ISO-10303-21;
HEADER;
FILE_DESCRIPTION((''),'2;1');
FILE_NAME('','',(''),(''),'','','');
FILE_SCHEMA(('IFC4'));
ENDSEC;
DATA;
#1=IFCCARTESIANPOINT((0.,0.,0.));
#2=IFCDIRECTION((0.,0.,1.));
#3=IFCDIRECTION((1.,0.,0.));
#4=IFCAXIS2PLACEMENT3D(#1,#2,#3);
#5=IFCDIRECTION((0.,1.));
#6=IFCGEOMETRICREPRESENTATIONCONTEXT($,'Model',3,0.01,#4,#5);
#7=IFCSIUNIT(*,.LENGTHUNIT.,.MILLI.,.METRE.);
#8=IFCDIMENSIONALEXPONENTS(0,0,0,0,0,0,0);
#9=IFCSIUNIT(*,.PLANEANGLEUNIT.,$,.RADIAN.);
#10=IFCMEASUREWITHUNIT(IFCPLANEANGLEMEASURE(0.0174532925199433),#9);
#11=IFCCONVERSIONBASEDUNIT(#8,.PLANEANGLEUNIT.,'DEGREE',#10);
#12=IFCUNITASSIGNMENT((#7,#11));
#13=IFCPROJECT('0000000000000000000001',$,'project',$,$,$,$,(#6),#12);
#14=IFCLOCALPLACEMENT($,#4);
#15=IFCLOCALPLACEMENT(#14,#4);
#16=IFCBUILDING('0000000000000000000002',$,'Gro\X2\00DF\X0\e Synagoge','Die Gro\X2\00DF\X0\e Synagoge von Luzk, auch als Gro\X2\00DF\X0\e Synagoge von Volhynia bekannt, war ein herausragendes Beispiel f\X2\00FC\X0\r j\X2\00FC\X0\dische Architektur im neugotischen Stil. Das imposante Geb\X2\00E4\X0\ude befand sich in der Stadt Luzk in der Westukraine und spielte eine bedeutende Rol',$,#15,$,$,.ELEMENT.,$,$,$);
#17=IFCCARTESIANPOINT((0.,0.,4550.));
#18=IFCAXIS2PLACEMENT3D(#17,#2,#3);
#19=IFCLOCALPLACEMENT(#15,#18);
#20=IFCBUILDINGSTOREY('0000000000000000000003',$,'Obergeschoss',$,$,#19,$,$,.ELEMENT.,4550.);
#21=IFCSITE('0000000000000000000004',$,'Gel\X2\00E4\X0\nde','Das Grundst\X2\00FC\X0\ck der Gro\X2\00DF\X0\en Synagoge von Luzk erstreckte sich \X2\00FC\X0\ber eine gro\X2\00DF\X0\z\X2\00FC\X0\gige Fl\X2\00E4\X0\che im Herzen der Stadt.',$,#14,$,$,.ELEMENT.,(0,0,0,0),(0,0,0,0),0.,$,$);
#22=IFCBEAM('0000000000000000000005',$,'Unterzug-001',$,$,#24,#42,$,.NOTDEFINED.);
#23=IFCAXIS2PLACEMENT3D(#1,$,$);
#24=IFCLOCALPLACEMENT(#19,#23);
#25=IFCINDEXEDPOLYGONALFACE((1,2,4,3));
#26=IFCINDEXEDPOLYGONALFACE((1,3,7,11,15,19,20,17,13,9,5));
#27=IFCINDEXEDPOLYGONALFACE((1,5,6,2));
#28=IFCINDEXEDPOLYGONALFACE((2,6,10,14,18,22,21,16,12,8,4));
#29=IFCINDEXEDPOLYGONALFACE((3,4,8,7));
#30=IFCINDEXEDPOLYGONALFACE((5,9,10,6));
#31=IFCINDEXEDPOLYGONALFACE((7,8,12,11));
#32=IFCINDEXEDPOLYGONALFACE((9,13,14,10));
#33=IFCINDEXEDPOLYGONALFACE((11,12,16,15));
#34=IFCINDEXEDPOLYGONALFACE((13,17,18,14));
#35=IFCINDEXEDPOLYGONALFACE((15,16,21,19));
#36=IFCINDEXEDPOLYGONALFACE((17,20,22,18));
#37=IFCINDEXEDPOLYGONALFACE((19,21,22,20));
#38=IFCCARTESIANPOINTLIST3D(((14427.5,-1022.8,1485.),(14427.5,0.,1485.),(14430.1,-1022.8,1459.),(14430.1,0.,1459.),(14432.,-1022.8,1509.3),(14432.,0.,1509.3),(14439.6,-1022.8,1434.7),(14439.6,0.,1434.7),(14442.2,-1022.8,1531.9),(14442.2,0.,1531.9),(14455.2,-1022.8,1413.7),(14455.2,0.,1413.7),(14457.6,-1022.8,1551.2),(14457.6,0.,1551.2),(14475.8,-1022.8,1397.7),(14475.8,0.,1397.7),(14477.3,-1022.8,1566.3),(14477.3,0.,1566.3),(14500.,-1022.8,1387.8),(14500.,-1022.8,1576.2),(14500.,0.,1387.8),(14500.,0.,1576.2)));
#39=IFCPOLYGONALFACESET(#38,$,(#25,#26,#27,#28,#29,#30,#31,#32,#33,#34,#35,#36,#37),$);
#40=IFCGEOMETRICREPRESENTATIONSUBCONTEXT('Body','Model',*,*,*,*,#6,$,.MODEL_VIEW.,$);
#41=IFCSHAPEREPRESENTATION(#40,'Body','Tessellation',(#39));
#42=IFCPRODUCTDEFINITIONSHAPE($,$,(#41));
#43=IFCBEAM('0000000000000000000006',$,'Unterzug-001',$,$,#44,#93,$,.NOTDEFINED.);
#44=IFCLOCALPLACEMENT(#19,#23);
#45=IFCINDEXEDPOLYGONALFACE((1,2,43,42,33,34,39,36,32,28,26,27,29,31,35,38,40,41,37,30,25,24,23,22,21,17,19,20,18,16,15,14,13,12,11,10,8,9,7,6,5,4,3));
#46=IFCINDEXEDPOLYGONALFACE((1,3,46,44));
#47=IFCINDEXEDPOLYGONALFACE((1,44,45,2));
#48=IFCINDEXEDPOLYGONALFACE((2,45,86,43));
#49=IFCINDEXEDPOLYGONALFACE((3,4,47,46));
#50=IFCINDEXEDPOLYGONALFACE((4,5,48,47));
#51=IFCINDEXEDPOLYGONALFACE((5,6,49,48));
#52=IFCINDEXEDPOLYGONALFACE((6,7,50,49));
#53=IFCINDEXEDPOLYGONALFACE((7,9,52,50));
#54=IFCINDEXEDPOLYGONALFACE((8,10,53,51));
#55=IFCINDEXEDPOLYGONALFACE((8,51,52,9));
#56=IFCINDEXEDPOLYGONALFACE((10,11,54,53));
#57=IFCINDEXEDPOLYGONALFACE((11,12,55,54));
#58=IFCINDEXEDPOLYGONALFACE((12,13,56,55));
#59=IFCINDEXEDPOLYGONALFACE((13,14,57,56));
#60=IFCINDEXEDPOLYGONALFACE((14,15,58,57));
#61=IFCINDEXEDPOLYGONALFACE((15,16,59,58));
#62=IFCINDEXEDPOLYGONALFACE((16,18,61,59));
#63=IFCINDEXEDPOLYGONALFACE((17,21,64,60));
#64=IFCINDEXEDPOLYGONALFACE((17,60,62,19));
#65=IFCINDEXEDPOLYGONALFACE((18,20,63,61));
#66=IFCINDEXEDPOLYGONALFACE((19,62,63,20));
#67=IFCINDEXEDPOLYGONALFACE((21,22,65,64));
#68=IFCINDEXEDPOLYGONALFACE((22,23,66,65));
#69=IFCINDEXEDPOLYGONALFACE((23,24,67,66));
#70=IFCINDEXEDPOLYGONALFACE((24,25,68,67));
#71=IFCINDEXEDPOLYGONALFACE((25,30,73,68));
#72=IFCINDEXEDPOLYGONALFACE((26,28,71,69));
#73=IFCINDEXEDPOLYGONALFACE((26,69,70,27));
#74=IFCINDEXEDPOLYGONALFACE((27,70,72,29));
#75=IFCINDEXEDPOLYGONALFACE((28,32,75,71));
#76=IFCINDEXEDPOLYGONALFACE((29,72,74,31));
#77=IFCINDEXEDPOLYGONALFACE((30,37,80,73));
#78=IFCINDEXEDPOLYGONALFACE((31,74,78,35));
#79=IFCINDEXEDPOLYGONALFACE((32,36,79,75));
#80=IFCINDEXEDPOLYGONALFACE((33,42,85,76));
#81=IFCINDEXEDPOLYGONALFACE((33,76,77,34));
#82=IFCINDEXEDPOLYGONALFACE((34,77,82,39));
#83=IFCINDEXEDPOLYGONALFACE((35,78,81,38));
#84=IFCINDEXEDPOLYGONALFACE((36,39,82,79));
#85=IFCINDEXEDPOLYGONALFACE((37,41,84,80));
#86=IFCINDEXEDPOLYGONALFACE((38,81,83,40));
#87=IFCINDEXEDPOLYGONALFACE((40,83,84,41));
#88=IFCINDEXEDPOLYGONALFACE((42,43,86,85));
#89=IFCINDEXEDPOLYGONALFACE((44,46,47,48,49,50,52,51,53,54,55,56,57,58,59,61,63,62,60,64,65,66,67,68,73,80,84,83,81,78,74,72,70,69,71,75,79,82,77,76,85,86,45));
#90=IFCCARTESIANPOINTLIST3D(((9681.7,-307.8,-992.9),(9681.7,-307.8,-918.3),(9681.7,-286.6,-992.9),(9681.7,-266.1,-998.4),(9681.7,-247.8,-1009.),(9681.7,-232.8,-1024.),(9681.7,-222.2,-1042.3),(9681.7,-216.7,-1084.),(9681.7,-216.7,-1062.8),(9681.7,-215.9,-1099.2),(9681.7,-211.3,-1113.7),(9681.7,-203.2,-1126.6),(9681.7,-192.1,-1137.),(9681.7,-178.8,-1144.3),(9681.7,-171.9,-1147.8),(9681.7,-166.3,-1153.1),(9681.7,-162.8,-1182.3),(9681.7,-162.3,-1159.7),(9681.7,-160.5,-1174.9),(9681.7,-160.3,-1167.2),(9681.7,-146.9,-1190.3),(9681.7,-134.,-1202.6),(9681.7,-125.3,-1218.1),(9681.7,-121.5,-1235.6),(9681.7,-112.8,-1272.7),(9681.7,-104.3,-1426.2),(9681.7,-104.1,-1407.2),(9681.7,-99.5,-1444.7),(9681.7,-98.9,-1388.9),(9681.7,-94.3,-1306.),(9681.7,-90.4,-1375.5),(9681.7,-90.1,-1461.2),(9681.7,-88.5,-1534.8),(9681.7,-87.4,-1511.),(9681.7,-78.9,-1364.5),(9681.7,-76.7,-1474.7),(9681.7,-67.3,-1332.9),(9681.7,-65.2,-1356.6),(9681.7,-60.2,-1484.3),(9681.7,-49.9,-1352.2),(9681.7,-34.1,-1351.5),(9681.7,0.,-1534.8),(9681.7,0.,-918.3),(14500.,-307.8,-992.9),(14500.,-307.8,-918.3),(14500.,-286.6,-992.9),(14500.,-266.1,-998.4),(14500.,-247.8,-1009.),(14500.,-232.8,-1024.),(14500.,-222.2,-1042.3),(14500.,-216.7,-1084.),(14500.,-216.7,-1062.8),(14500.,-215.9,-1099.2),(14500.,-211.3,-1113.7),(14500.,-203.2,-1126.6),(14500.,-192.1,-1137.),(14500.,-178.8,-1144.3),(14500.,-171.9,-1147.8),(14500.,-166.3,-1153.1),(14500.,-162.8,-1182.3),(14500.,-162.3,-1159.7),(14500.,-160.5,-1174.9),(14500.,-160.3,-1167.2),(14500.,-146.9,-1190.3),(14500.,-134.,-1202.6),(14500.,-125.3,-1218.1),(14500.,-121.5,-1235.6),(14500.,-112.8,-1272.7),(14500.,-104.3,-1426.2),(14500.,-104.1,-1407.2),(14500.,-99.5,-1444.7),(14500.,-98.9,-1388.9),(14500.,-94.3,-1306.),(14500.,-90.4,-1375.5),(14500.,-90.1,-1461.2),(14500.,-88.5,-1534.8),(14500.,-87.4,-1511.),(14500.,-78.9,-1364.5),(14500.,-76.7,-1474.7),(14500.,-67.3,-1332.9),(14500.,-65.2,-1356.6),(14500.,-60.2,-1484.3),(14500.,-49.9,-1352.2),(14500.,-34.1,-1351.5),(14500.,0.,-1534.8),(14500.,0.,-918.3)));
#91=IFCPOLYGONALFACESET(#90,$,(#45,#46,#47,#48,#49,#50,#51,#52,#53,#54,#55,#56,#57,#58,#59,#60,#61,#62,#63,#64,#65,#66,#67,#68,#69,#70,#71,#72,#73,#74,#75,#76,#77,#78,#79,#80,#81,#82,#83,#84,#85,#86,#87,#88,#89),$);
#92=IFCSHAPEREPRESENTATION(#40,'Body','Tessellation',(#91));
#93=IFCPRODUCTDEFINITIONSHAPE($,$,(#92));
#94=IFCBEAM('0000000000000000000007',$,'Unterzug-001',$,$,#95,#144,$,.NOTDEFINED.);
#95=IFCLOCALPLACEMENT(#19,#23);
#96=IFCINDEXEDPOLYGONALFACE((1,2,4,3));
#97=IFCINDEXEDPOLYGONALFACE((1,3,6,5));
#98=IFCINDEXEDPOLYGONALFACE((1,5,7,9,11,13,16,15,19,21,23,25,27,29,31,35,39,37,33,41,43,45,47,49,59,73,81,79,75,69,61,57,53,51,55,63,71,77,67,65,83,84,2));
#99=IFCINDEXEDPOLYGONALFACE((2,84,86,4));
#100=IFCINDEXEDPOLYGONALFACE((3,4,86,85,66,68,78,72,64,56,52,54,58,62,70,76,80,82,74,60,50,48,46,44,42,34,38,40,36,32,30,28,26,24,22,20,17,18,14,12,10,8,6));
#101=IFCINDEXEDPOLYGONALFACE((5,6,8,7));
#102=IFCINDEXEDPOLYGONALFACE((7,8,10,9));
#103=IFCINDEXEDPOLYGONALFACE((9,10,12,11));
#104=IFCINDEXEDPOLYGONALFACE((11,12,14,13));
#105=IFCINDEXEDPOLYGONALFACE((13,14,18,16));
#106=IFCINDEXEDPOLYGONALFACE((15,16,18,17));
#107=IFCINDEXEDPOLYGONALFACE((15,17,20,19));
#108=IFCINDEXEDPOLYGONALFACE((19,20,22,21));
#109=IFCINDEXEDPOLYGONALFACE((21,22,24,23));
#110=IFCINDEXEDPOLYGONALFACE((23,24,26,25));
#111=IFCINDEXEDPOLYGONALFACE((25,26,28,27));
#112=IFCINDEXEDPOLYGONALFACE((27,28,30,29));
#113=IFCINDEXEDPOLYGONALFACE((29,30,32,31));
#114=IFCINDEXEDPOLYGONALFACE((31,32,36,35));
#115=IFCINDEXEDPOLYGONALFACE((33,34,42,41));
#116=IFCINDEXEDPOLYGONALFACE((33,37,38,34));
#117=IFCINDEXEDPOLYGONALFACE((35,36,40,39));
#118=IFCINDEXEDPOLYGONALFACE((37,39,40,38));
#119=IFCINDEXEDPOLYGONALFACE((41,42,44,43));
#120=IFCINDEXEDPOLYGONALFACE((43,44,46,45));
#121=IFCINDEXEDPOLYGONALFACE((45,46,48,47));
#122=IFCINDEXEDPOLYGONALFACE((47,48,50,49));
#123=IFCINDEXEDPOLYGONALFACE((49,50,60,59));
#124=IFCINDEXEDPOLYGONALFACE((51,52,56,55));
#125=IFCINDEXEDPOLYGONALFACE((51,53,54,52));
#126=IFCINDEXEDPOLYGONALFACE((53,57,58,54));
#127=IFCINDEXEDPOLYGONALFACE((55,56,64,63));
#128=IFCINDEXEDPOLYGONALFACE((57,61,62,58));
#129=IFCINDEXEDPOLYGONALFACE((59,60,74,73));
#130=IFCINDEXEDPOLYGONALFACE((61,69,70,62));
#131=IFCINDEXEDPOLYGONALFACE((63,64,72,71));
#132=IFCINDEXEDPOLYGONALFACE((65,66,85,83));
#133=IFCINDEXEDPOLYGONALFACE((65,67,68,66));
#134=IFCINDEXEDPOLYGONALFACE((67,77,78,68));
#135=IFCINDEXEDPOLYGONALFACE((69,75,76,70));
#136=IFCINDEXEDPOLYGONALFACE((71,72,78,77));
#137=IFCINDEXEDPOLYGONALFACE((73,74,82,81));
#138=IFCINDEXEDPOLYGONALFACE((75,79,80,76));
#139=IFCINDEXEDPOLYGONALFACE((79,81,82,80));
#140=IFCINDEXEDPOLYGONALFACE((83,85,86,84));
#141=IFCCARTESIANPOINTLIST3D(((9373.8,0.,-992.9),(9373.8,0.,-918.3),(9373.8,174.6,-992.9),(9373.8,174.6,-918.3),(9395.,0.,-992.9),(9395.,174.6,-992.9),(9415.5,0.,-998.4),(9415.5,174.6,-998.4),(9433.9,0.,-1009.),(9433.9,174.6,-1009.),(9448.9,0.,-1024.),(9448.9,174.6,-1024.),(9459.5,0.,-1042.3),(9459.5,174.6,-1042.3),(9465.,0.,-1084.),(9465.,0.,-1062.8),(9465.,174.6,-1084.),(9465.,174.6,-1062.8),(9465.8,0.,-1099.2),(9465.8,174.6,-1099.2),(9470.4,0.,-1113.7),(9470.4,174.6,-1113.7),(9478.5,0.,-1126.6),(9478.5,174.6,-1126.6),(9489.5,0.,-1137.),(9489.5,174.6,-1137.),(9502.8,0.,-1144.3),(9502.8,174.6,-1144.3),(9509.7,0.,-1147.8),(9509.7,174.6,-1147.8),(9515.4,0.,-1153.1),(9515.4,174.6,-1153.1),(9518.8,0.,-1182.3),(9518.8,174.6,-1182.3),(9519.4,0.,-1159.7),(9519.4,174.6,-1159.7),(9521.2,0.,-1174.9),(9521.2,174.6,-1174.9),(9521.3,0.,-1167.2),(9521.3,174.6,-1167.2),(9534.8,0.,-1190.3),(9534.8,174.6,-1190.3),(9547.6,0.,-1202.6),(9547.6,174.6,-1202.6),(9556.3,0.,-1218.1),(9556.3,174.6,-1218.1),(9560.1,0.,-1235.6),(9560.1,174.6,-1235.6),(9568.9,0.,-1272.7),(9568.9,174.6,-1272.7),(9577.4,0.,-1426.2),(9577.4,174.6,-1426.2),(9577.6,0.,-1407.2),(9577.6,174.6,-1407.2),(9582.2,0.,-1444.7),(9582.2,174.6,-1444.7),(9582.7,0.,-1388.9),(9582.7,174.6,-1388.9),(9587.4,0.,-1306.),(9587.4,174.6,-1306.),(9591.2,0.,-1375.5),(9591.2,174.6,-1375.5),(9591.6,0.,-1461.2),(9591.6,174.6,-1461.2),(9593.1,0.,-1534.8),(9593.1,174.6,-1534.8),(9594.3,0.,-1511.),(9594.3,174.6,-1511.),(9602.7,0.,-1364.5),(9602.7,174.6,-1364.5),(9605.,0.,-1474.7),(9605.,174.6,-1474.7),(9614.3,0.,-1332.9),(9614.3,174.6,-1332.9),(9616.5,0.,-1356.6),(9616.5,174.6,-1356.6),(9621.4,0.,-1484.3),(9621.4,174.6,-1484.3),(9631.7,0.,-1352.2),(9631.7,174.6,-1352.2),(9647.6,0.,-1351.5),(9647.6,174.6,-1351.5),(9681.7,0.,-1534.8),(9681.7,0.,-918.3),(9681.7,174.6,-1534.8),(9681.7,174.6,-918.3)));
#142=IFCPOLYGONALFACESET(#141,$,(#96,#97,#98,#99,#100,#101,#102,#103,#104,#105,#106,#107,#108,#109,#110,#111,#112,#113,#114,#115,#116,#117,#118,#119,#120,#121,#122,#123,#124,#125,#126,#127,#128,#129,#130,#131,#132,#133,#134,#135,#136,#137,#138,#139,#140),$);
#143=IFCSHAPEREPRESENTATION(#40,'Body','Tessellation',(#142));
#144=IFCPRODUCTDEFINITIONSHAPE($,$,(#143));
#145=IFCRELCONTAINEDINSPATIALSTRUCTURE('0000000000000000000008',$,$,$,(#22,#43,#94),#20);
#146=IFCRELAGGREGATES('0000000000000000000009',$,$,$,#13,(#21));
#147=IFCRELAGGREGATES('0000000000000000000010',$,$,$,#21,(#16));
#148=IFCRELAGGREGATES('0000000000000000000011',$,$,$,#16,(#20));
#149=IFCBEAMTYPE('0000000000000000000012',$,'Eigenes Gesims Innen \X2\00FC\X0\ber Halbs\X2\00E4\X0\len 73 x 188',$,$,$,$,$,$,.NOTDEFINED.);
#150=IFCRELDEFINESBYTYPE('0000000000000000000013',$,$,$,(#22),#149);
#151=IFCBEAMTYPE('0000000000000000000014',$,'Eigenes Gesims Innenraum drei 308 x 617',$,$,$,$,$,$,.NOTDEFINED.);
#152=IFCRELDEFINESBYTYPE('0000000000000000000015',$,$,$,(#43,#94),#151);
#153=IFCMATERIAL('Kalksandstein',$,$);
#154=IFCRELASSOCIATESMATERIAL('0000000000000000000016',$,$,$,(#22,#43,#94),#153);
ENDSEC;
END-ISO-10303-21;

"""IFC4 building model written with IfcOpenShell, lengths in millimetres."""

from ifc_helpers import new_model, entity, si_unit, converted_unit, direction, frame, origin_with_axes, place, context, subcontext, project, spatial, line, arc, indexed_curve, outline, extrude, material, material_profile, profile_set, type_object, element, save


model = new_model("IFC4")

# Units and contexts
model_context = context("Model", 3, precision=0.01, world=origin_with_axes(), true_north=direction((0.0, 1.0)))
body_context = subcontext(model_context, "Body", "Model", "MODEL_VIEW")
ifc_project = project(units=[si_unit("LENGTHUNIT", "METRE", prefix="MILLI"), converted_unit("PLANEANGLEUNIT", "DEGREE", entity("IfcPlaneAngleMeasure", 0.0174532925199433), si_unit("PLANEANGLEUNIT", "RADIAN"), dimensions=[0, 0, 0, 0, 0, 0, 0])], contexts=[model_context])

# Site, building, storey
site_placement = place(None, origin_with_axes())
site = spatial("IfcSite", under=ifc_project, at=site_placement, Name="Gelände", Description="Das Grundstück der Großen Synagoge von Luzk erstreckte sich über eine großzügige Fläche im Herzen der Stadt.", CompositionType="ELEMENT", RefLatitude=(0, 0, 0, 0), RefLongitude=(0, 0, 0, 0), RefElevation=0.0)
building_placement = place(site_placement, origin_with_axes())
building = spatial("IfcBuilding", under=site, at=building_placement, Name="Große Synagoge", Description="Die Große Synagoge von Luzk, auch als Große Synagoge von Volhynia bekannt, war ein herausragendes Beispiel für jüdische Architektur im neugotischen Stil. Das imposante Gebäude befand sich in der Stadt Luzk in der Westukraine und spielte eine bedeutende Rol", CompositionType="ELEMENT")
storey_placement = place(building_placement, frame((0.0, 0.0, 4550.0), z_axis=(0.0, 0.0, 1.0), x_axis=(1.0, 0.0, 0.0)))
storey = spatial("IfcBuildingStorey", under=building, at=storey_placement, Name="Obergeschoss", CompositionType="ELEMENT", Elevation=4550.0)

# Beams
ifc_material_1 = material(Name="Kalksandstein")
ifc_material_profile_1 = material_profile(ifc_material_1, outline(indexed_curve([(72.5, -91.2), (50.7, -34.1), (0.0, 0.0), (0.0, -188.3), (53.3, -152.5)], segments=[arc(1, 2, 3), line(3, 4), arc(4, 5, 1)])), Name="Kalksandstein")
ifc_profile_set_1 = profile_set([ifc_material_profile_1], Name="Eigenes Gesims Innen über Halbsälen")
beam_type_1 = type_object("IfcBeamType", Name="Eigenes Gesims Innen über Halbsälen 73 x 188", PredefinedType="NOTDEFINED")
beam_1_placement = place(storey_placement, frame((14500.0, -1022.8, 1576.2), z_axis=(0.0, 0.0, 1.0), x_axis=(1.0, 0.0, 0.0)))
element("IfcBeam", 1, at=beam_1_placement, inside=storey, type_object=beam_type_1, material=ifc_profile_set_1, Name="Unterzug-001", PredefinedType="NOTDEFINED", context=body_context, shape_type="SweptSolid", body=[
    extrude(outline(indexed_curve([(72.5, -91.2), (50.7, -34.1), (0.0, 0.0), (0.0, -188.3), (53.3, -152.5)], segments=[arc(1, 2, 3), line(3, 4), arc(4, 5, 1)])), frame((0.0, 1022.8, 0.0), z_axis=(0.0, 1.0, 0.0), x_axis=(-1.0, 0.0, 0.0)), (0.0, 0.0, -1.0), 1022.8),
])
ifc_material_profile_2 = material_profile(ifc_material_1, outline(indexed_curve([(121.5, -317.3), (134.0, -284.3), (162.8, -264.0), (162.3, -241.4), (178.8, -226.0), (207.7, -202.1), (216.7, -165.7), (239.8, -97.7), (307.8, -74.6), (307.8, 0.0), (0.0, 0.0), (0.0, -616.6), (88.5, -616.6), (87.4, -592.7), (60.2, -566.0), (99.5, -526.4), (98.9, -470.6), (72.3, -441.9), (34.1, -433.2), (94.3, -387.7)], segments=[arc(1, 2, 3), arc(3, 4, 5), arc(5, 6, 7), arc(7, 8, 9), line(9, 10, 11, 12, 13, 14, 15), arc(15, 16, 17), arc(17, 18, 19), arc(19, 20, 1)])), Name="Kalksandstein")
ifc_profile_set_2 = profile_set([ifc_material_profile_2], Name="Eigenes Gesims Innenraum drei")
beam_type_2 = type_object("IfcBeamType", Name="Eigenes Gesims Innenraum drei 308 x 617", PredefinedType="NOTDEFINED")
beam_2_placement = place(storey_placement, frame((9681.7, 0.0, -918.3), z_axis=(0.0, 0.0, 1.0), x_axis=(0.0, -1.0, 0.0)))
element("IfcBeam", 2, at=beam_2_placement, inside=storey, type_object=beam_type_2, material=ifc_profile_set_2, Name="Unterzug-001", PredefinedType="NOTDEFINED", context=body_context, shape_type="SweptSolid", body=[
    extrude(outline(indexed_curve([(121.5, -317.3), (134.0, -284.3), (162.8, -264.0), (162.3, -241.4), (178.8, -226.0), (207.7, -202.1), (216.7, -165.7), (239.8, -97.7), (307.8, -74.6), (307.8, 0.0), (0.0, 0.0), (0.0, -616.6), (88.5, -616.6), (87.4, -592.7), (60.2, -566.0), (99.5, -526.4), (98.9, -470.6), (72.3, -441.9), (34.1, -433.2), (94.3, -387.7)], segments=[arc(1, 2, 3), arc(3, 4, 5), arc(5, 6, 7), arc(7, 8, 9), line(9, 10, 11, 12, 13, 14, 15), arc(15, 16, 17), arc(17, 18, 19), arc(19, 20, 1)])), frame((0.0, 4818.3, 0.0), z_axis=(0.0, -1.0, 0.0), x_axis=(1.0, 0.0, 0.0)), (0.0, 0.0, 1.0), 4818.3),
])
beam_3_placement = place(storey_placement, frame((9681.7, 174.6, -918.3), z_axis=(0.0, 0.0, 1.0), x_axis=(-1.0, 0.0, 0.0)))
element("IfcBeam", 3, at=beam_3_placement, inside=storey, type_object=beam_type_2, material=ifc_profile_set_2, Name="Unterzug-001", PredefinedType="NOTDEFINED", context=body_context, shape_type="SweptSolid", body=[
    extrude(outline(indexed_curve([(121.5, -317.3), (134.0, -284.3), (162.8, -264.0), (162.3, -241.4), (178.8, -226.0), (207.7, -202.1), (216.7, -165.7), (239.8, -97.7), (307.8, -74.6), (307.8, 0.0), (0.0, 0.0), (0.0, -616.6), (88.5, -616.6), (87.4, -592.7), (60.2, -566.0), (99.5, -526.4), (98.9, -470.6), (72.3, -441.9), (34.1, -433.2), (94.3, -387.7)], segments=[arc(1, 2, 3), arc(3, 4, 5), arc(5, 6, 7), arc(7, 8, 9), line(9, 10, 11, 12, 13, 14, 15), arc(15, 16, 17), arc(17, 18, 19), arc(19, 20, 1)])), frame((0.0, 174.6, 0.0), z_axis=(0.0, -1.0, 0.0), x_axis=(1.0, 0.0, 0.0)), (0.0, 0.0, 1.0), 174.6),
])

save(model, "model.ifc")
